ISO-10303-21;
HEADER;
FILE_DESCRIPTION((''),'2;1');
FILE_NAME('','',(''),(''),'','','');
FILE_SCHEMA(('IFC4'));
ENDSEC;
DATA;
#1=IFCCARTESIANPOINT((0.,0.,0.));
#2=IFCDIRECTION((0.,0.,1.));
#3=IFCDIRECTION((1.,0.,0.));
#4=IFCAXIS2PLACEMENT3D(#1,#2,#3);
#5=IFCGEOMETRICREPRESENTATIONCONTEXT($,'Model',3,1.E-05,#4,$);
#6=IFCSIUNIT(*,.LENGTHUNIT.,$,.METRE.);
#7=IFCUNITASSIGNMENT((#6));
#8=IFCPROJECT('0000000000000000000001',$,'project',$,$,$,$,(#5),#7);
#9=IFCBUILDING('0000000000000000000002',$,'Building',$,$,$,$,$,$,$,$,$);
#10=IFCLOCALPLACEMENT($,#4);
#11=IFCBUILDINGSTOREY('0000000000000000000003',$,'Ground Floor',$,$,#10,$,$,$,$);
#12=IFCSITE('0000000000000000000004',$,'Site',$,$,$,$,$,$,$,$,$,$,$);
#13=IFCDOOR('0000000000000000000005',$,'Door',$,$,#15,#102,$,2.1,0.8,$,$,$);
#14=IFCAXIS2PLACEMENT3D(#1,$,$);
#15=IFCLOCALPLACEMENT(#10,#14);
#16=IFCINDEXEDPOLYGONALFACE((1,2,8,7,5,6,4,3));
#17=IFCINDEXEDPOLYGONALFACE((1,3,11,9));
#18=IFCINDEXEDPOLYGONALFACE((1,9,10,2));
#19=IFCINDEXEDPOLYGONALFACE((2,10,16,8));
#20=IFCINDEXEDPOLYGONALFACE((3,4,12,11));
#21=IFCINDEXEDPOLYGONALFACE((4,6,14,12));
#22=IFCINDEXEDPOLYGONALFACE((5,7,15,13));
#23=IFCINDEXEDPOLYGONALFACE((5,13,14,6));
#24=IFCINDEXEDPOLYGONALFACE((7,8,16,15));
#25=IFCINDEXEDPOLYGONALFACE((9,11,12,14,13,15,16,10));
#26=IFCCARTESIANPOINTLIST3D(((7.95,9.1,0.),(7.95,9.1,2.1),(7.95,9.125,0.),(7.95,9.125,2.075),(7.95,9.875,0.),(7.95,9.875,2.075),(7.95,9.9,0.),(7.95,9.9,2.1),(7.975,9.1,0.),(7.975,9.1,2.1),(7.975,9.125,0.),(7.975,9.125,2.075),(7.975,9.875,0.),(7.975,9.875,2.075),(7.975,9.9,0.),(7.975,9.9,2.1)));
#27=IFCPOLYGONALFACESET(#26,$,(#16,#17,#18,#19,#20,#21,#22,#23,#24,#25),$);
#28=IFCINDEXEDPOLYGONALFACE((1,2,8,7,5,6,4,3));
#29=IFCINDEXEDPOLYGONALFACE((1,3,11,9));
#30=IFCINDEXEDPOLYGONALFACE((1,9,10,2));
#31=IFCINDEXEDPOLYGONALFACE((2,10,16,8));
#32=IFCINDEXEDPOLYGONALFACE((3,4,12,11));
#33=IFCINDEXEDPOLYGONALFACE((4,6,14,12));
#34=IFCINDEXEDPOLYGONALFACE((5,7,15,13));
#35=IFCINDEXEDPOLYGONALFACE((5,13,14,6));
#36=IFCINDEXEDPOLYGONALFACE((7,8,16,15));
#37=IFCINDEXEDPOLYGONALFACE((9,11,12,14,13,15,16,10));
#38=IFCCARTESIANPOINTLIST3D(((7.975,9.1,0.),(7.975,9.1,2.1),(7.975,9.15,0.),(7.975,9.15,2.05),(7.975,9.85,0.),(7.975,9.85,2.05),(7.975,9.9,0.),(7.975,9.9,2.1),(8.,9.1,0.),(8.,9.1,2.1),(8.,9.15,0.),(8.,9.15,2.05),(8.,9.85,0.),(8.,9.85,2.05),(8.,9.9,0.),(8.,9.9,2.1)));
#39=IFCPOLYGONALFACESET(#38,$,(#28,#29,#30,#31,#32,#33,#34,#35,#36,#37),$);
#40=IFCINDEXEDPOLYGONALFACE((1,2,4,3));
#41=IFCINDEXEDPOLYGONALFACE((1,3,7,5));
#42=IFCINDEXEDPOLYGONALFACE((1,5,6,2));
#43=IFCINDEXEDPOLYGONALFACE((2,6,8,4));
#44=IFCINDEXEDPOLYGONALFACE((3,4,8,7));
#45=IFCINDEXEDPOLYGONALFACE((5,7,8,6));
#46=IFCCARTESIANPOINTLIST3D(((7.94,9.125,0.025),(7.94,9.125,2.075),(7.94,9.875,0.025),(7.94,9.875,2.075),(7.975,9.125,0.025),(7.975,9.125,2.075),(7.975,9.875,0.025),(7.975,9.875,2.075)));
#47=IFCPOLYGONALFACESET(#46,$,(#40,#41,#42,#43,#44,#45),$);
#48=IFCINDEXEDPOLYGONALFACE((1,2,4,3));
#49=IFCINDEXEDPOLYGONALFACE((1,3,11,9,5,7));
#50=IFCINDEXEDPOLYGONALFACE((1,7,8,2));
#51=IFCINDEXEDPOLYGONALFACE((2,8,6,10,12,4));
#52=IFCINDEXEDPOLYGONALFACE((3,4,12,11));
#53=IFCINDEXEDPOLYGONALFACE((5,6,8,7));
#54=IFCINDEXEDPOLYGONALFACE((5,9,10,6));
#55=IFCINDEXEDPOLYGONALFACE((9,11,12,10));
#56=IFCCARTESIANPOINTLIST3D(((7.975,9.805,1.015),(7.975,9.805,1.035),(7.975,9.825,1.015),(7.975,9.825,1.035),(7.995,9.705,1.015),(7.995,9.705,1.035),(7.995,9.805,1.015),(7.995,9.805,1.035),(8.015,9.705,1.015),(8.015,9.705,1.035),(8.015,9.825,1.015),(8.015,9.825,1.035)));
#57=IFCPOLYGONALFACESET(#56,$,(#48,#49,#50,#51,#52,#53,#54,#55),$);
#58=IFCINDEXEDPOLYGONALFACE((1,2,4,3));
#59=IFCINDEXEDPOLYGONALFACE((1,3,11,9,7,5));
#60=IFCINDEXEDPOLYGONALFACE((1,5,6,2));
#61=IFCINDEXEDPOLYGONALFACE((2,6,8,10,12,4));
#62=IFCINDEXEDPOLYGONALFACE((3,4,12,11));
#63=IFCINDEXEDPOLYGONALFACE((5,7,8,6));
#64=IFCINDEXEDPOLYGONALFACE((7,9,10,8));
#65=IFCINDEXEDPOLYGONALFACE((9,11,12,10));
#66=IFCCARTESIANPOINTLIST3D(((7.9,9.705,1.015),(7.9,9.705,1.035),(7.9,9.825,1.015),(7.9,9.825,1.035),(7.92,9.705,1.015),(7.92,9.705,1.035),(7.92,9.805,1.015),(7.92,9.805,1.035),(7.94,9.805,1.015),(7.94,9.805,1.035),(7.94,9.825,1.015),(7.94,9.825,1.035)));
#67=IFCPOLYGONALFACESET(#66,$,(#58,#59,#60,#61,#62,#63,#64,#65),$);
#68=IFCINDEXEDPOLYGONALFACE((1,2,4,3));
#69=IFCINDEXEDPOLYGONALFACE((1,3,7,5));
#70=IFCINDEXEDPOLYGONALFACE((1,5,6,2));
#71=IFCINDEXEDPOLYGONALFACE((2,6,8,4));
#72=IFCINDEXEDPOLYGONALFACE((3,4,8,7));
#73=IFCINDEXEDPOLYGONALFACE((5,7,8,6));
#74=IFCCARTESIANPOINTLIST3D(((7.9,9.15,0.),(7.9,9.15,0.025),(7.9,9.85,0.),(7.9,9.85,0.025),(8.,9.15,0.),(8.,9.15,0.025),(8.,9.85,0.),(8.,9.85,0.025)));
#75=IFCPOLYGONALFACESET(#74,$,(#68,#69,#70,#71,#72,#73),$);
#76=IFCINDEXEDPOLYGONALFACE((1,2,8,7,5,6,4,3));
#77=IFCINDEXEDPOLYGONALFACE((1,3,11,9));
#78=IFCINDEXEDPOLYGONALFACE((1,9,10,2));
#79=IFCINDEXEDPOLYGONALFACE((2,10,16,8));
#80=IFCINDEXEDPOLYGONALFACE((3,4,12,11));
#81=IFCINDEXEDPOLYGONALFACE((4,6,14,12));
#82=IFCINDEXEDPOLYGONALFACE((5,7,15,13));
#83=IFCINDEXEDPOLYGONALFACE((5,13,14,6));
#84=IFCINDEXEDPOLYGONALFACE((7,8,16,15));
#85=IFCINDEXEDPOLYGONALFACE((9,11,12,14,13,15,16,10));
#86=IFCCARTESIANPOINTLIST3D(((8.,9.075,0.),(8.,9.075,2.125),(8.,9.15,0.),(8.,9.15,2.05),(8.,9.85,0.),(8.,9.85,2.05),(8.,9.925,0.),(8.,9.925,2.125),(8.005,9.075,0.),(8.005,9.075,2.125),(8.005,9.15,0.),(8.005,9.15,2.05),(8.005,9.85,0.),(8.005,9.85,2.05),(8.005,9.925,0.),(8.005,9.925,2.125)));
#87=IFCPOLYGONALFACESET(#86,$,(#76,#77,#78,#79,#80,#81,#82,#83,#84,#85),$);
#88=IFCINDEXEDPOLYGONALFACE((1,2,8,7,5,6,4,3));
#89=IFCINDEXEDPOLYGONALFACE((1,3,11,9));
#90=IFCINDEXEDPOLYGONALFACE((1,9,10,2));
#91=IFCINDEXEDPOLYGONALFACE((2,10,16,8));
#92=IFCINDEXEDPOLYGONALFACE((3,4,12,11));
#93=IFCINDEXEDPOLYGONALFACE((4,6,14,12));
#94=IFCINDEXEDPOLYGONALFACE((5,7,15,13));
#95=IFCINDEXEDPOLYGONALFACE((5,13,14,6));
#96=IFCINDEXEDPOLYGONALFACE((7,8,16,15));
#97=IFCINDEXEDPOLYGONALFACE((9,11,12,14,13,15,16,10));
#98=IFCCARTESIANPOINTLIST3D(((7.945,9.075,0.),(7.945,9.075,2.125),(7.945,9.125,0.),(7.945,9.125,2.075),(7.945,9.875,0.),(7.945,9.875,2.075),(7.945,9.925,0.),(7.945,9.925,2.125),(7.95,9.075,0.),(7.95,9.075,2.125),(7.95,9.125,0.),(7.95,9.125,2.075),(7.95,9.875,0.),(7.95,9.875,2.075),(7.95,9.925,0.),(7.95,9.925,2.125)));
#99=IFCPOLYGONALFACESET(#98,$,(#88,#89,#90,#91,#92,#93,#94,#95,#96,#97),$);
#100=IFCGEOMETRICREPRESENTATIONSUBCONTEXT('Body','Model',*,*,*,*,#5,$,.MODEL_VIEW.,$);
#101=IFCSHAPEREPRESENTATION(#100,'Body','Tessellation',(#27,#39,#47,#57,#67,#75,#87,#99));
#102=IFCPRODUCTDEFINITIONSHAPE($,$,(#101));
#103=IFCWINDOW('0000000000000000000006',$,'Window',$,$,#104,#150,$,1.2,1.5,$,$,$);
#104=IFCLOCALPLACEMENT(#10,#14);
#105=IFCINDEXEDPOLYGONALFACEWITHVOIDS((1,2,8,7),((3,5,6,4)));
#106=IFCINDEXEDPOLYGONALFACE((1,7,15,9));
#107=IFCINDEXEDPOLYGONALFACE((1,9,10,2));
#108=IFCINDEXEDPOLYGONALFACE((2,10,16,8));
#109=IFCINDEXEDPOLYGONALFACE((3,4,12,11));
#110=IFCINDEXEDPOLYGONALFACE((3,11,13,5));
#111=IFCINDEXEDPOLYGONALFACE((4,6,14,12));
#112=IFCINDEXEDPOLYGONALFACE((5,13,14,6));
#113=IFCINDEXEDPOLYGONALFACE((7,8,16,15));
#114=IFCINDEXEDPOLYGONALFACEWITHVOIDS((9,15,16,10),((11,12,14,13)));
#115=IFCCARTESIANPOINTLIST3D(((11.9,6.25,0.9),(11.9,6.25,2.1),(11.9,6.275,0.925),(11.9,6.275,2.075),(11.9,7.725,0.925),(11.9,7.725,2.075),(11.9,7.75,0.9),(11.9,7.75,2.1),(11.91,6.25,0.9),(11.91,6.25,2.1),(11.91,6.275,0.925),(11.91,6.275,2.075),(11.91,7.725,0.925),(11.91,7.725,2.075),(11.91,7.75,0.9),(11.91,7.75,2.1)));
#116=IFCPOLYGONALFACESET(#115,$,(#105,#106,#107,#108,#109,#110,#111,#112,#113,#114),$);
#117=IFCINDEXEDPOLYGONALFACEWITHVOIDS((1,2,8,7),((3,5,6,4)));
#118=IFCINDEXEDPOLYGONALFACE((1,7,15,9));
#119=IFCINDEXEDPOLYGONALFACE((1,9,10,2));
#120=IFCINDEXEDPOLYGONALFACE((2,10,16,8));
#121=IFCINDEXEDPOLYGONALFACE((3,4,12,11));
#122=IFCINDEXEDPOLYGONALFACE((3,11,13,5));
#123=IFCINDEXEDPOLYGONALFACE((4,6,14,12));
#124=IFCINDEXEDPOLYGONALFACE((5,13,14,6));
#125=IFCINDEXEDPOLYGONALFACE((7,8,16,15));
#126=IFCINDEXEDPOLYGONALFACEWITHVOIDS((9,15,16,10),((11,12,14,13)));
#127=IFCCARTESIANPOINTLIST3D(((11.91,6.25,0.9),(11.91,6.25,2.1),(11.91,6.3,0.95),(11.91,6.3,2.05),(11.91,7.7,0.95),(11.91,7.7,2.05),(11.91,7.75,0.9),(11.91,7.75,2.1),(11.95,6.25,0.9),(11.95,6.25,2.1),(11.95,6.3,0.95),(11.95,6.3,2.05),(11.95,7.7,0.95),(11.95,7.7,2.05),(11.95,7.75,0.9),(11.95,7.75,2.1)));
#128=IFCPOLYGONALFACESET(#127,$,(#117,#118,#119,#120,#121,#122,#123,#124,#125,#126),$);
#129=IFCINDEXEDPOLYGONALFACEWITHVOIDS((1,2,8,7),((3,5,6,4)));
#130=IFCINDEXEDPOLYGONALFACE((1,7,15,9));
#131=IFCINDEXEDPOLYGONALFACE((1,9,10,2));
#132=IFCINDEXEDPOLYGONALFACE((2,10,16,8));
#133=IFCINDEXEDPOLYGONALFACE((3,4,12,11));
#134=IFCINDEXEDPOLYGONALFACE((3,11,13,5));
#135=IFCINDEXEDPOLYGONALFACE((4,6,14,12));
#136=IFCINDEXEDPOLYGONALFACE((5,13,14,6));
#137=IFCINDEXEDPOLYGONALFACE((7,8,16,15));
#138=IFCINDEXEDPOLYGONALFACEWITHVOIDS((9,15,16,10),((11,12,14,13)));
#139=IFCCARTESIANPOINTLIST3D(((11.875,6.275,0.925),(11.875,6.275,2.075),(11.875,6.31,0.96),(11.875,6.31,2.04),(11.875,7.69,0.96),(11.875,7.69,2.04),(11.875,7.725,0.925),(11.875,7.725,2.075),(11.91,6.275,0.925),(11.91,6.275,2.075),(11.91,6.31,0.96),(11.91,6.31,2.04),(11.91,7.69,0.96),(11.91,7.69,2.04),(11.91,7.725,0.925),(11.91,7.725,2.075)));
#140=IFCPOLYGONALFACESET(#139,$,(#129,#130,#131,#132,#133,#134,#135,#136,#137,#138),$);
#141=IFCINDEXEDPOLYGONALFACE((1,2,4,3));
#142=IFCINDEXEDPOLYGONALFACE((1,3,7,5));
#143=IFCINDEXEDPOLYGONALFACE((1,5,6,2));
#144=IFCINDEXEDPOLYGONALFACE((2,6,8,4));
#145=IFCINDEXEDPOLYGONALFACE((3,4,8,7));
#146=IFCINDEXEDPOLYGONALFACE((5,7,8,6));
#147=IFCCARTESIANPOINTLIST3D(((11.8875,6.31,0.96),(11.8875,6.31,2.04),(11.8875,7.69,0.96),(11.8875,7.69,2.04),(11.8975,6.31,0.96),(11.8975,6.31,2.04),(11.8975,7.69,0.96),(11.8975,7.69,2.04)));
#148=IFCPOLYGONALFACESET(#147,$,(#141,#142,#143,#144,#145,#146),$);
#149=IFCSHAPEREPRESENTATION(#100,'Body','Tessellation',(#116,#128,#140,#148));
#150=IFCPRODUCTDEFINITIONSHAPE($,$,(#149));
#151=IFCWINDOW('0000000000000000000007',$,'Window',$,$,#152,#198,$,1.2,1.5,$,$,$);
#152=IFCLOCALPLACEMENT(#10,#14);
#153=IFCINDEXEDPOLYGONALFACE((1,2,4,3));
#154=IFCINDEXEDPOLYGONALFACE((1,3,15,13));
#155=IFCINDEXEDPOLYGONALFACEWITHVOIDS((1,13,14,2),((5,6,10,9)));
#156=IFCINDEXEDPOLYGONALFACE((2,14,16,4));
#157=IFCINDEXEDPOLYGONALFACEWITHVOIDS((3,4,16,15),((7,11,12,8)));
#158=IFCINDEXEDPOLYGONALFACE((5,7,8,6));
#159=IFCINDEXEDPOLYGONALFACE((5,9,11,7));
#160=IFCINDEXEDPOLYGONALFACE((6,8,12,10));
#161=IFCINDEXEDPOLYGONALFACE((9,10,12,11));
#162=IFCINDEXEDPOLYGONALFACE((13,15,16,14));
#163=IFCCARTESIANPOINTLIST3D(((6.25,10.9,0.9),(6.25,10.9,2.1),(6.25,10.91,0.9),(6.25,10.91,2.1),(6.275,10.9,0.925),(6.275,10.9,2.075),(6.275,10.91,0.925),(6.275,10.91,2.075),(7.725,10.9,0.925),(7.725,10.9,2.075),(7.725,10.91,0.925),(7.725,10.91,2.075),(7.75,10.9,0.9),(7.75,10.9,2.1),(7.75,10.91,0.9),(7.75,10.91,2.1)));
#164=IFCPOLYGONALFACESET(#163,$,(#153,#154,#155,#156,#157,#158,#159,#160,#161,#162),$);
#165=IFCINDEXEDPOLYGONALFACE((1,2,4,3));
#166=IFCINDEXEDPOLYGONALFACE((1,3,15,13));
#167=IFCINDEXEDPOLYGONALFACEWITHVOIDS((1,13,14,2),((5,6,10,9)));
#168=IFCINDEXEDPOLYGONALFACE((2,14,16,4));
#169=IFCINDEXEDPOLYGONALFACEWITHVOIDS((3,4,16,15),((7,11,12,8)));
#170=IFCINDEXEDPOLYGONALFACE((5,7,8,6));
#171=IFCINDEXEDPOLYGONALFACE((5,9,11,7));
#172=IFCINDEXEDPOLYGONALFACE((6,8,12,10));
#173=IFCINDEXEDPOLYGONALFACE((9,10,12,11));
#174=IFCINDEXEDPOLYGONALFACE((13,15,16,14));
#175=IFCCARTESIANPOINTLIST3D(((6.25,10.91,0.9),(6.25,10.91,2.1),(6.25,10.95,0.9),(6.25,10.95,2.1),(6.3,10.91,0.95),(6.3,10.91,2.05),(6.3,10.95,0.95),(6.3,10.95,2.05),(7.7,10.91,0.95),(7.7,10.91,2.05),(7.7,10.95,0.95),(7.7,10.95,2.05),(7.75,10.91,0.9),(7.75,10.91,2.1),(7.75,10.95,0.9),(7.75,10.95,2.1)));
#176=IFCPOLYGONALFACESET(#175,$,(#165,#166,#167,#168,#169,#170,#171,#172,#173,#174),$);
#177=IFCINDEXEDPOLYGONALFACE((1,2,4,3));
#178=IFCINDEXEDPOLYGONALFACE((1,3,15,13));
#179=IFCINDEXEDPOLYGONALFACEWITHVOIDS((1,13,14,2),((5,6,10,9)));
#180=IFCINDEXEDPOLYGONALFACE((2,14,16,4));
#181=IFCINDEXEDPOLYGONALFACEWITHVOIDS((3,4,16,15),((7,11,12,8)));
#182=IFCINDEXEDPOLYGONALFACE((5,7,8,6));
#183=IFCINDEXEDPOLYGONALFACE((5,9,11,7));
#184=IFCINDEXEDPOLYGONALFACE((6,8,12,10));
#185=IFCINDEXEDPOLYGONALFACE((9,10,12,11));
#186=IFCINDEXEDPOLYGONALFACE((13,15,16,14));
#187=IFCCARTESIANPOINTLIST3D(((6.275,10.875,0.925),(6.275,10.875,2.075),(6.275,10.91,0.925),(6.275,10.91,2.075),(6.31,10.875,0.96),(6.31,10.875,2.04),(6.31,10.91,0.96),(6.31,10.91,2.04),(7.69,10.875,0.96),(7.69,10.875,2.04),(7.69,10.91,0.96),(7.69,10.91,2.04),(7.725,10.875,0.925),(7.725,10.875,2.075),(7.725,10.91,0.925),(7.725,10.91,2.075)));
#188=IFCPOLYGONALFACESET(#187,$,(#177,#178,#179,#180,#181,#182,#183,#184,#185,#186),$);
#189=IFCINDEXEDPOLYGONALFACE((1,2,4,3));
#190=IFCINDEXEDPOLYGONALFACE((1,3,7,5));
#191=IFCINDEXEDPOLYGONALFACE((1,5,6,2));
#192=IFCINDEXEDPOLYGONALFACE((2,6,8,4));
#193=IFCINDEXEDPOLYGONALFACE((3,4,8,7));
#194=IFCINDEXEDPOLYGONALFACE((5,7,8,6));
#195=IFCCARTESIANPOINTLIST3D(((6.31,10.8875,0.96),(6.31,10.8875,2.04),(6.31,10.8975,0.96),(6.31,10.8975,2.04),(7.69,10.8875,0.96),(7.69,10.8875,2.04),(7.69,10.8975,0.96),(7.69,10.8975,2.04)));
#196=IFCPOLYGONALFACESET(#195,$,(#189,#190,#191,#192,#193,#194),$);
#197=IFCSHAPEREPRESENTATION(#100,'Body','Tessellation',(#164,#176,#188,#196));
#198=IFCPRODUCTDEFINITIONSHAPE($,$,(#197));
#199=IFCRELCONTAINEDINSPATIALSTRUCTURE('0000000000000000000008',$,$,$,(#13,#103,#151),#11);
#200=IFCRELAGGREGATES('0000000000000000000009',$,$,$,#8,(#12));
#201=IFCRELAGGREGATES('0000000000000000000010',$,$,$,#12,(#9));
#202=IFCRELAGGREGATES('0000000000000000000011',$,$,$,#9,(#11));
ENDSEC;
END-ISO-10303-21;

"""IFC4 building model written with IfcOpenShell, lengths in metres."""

from ifc_helpers import new_model, si_unit, frame, origin_with_axes, place, context, subcontext, project, spatial, line, indexed_curve, outline, extrude, element, save


model = new_model("IFC4")

# Units and contexts
model_context = context("Model", 3, precision=1e-05, world=origin_with_axes())
body_context = subcontext(model_context, "Body", "Model", "MODEL_VIEW")
ifc_project = project(units=[si_unit("LENGTHUNIT", "METRE")], contexts=[model_context])

# Site, building, storey
site = spatial("IfcSite", under=ifc_project, Name="Site")
building = spatial("IfcBuilding", under=site, Name="Building")
storey_placement = place(None, origin_with_axes())
storey = spatial("IfcBuildingStorey", under=building, at=storey_placement, Name="Ground Floor")

# Door
door_1_placement = place(storey_placement, frame((8.0, 9.1, 0.0), z_axis=(0.0, 0.0, 1.0), x_axis=(0.0, 1.0, 0.0)))
element("IfcDoor", 1, at=door_1_placement, inside=storey, Name="Door", OverallHeight=2.1, OverallWidth=0.8, context=body_context, shape_type="SweptSolid", body=[
    extrude(outline(indexed_curve([(0.0, 0.0), (0.0, 2.1), (0.8, 2.1), (0.8, 0.0), (0.775, 0.0), (0.775, 2.075), (0.025, 2.075), (0.025, 0.0)], segments=[line(1, 2, 3, 4, 5, 6, 7, 8, 1)])), frame((0.0, 0.025, 0.0), z_axis=(0.0, -1.0, 0.0), x_axis=(1.0, 0.0, 0.0)), (0.0, 0.0, -1.0), 0.025),
    extrude(outline(indexed_curve([(0.0, 0.0), (0.0, 2.1), (0.8, 2.1), (0.8, 0.0), (0.75, 0.0), (0.75, 2.05), (0.05, 2.05), (0.05, 0.0)], segments=[line(1, 2, 3, 4, 5, 6, 7, 8, 1)])), frame((0.0, 0.0, 0.0), z_axis=(0.0, -1.0, 0.0), x_axis=(1.0, 0.0, 0.0)), (0.0, 0.0, -1.0), 0.025),
    extrude(outline(indexed_curve([(0.0, 0.0), (0.75, 0.0), (0.75, 0.035), (0.0, 0.035)], segments=[line(1, 2, 3, 4, 1)])), frame((0.025, 0.025, 0.025), z_axis=(0.0, 0.0, 1.0), x_axis=(1.0, 0.0, 0.0)), (0.0, 0.0, 1.0), 2.05),
    extrude(outline(indexed_curve([(0.0, 0.0), (0.0, -0.04), (-0.12, -0.04), (-0.12, -0.02), (-0.02, -0.02), (-0.02, 0.0)], segments=[line(1, 2, 3, 4, 5, 6, 1)])), frame((0.725, 0.025, 1.015), z_axis=(0.0, 0.0, 1.0), x_axis=(1.0, 0.0, 0.0)), (0.0, 0.0, 1.0), 0.02),
    extrude(outline(indexed_curve([(0.0, 0.0), (0.0, 0.04), (-0.12, 0.04), (-0.12, 0.02), (-0.02, 0.02), (-0.02, 0.0)], segments=[line(1, 2, 3, 4, 5, 6, 1)])), frame((0.725, 0.06, 1.015), z_axis=(0.0, 0.0, 1.0), x_axis=(1.0, 0.0, 0.0)), (0.0, 0.0, 1.0), 0.02),
    extrude(outline(indexed_curve([(0.0, 0.0), (0.7, 0.0), (0.7, 0.1), (0.0, 0.1)], segments=[line(1, 2, 3, 4, 1)])), frame((0.05, 0.0, 0.0), z_axis=(0.0, 0.0, 1.0), x_axis=(1.0, 0.0, 0.0)), (0.0, 0.0, 1.0), 0.025),
    extrude(outline(indexed_curve([(0.0, 0.0), (0.0, 2.125), (0.85, 2.125), (0.85, 0.0), (0.775, 0.0), (0.775, 2.05), (0.075, 2.05), (0.075, 0.0)], segments=[line(1, 2, 3, 4, 5, 6, 7, 8, 1)])), frame((-0.025, -0.005, 0.0), z_axis=(0.0, -1.0, 0.0), x_axis=(1.0, 0.0, 0.0)), (0.0, 0.0, -1.0), 0.005),
    extrude(outline(indexed_curve([(0.0, 0.0), (0.0, 2.125), (0.85, 2.125), (0.85, 0.0), (0.8, 0.0), (0.8, 2.075), (0.05, 2.075), (0.05, 0.0)], segments=[line(1, 2, 3, 4, 5, 6, 7, 8, 1)])), frame((-0.025, 0.05, 0.0), z_axis=(0.0, -1.0, 0.0), x_axis=(1.0, 0.0, 0.0)), (0.0, 0.0, -1.0), 0.005),
])

# Windows
for number, where, z_axis, x_axis, name in (
    (2, (12.0, 6.25, 0.9), (0.0, 0.0, 1.0), (0.0, 1.0, 0.0), "Window"),
    (3, (7.75, 11.0, 0.9), (0.0, 0.0, 1.0), (-1.0, 0.0, 0.0), "Window"),
):
    element("IfcWindow", number, at=place(storey_placement, frame(where, z_axis=z_axis, x_axis=x_axis)), inside=storey, Name=name, OverallHeight=1.2, OverallWidth=1.5, context=body_context, shape_type="SweptSolid", body=[
        extrude(outline(indexed_curve([(0.0, 0.0), (1.5, 0.0), (1.5, 1.2), (0.0, 1.2)], segments=[line(1, 2, 3, 4, 1)]), holes=[indexed_curve([(0.025, 0.025), (1.475, 0.025), (1.475, 1.175), (0.025, 1.175)], segments=[line(1, 2, 3, 4, 1)])]), frame((0.0, 0.09, 0.0), z_axis=(0.0, -1.0, 0.0), x_axis=(1.0, 0.0, 0.0)), (0.0, 0.0, -1.0), 0.01),
        extrude(outline(indexed_curve([(0.0, 0.0), (1.5, 0.0), (1.5, 1.2), (0.0, 1.2)], segments=[line(1, 2, 3, 4, 1)]), holes=[indexed_curve([(0.05, 0.05), (1.45, 0.05), (1.45, 1.15), (0.05, 1.15)], segments=[line(1, 2, 3, 4, 1)])]), frame((0.0, 0.05, 0.0), z_axis=(0.0, -1.0, 0.0), x_axis=(1.0, 0.0, 0.0)), (0.0, 0.0, -1.0), 0.04),
        extrude(outline(indexed_curve([(0.0, 0.0), (1.45, 0.0), (1.45, 1.15), (0.0, 1.15)], segments=[line(1, 2, 3, 4, 1)]), holes=[indexed_curve([(0.035, 0.035), (1.415, 0.035), (1.415, 1.115), (0.035, 1.115)], segments=[line(1, 2, 3, 4, 1)])]), frame((0.025, 0.09, 0.025), z_axis=(0.0, -1.0, 0.0), x_axis=(1.0, 0.0, 0.0)), (0.0, 0.0, -1.0), 0.035),
        extrude(outline(indexed_curve([(0.035, 0.035), (1.415, 0.035), (1.415, 1.115), (0.035, 1.115)], segments=[line(1, 2, 3, 4, 1)])), frame((0.025, 0.1025, 0.025), z_axis=(0.0, -1.0, 0.0), x_axis=(1.0, 0.0, 0.0)), (0.0, 0.0, -1.0), 0.01),
    ])

save(model, "model.ifc")
